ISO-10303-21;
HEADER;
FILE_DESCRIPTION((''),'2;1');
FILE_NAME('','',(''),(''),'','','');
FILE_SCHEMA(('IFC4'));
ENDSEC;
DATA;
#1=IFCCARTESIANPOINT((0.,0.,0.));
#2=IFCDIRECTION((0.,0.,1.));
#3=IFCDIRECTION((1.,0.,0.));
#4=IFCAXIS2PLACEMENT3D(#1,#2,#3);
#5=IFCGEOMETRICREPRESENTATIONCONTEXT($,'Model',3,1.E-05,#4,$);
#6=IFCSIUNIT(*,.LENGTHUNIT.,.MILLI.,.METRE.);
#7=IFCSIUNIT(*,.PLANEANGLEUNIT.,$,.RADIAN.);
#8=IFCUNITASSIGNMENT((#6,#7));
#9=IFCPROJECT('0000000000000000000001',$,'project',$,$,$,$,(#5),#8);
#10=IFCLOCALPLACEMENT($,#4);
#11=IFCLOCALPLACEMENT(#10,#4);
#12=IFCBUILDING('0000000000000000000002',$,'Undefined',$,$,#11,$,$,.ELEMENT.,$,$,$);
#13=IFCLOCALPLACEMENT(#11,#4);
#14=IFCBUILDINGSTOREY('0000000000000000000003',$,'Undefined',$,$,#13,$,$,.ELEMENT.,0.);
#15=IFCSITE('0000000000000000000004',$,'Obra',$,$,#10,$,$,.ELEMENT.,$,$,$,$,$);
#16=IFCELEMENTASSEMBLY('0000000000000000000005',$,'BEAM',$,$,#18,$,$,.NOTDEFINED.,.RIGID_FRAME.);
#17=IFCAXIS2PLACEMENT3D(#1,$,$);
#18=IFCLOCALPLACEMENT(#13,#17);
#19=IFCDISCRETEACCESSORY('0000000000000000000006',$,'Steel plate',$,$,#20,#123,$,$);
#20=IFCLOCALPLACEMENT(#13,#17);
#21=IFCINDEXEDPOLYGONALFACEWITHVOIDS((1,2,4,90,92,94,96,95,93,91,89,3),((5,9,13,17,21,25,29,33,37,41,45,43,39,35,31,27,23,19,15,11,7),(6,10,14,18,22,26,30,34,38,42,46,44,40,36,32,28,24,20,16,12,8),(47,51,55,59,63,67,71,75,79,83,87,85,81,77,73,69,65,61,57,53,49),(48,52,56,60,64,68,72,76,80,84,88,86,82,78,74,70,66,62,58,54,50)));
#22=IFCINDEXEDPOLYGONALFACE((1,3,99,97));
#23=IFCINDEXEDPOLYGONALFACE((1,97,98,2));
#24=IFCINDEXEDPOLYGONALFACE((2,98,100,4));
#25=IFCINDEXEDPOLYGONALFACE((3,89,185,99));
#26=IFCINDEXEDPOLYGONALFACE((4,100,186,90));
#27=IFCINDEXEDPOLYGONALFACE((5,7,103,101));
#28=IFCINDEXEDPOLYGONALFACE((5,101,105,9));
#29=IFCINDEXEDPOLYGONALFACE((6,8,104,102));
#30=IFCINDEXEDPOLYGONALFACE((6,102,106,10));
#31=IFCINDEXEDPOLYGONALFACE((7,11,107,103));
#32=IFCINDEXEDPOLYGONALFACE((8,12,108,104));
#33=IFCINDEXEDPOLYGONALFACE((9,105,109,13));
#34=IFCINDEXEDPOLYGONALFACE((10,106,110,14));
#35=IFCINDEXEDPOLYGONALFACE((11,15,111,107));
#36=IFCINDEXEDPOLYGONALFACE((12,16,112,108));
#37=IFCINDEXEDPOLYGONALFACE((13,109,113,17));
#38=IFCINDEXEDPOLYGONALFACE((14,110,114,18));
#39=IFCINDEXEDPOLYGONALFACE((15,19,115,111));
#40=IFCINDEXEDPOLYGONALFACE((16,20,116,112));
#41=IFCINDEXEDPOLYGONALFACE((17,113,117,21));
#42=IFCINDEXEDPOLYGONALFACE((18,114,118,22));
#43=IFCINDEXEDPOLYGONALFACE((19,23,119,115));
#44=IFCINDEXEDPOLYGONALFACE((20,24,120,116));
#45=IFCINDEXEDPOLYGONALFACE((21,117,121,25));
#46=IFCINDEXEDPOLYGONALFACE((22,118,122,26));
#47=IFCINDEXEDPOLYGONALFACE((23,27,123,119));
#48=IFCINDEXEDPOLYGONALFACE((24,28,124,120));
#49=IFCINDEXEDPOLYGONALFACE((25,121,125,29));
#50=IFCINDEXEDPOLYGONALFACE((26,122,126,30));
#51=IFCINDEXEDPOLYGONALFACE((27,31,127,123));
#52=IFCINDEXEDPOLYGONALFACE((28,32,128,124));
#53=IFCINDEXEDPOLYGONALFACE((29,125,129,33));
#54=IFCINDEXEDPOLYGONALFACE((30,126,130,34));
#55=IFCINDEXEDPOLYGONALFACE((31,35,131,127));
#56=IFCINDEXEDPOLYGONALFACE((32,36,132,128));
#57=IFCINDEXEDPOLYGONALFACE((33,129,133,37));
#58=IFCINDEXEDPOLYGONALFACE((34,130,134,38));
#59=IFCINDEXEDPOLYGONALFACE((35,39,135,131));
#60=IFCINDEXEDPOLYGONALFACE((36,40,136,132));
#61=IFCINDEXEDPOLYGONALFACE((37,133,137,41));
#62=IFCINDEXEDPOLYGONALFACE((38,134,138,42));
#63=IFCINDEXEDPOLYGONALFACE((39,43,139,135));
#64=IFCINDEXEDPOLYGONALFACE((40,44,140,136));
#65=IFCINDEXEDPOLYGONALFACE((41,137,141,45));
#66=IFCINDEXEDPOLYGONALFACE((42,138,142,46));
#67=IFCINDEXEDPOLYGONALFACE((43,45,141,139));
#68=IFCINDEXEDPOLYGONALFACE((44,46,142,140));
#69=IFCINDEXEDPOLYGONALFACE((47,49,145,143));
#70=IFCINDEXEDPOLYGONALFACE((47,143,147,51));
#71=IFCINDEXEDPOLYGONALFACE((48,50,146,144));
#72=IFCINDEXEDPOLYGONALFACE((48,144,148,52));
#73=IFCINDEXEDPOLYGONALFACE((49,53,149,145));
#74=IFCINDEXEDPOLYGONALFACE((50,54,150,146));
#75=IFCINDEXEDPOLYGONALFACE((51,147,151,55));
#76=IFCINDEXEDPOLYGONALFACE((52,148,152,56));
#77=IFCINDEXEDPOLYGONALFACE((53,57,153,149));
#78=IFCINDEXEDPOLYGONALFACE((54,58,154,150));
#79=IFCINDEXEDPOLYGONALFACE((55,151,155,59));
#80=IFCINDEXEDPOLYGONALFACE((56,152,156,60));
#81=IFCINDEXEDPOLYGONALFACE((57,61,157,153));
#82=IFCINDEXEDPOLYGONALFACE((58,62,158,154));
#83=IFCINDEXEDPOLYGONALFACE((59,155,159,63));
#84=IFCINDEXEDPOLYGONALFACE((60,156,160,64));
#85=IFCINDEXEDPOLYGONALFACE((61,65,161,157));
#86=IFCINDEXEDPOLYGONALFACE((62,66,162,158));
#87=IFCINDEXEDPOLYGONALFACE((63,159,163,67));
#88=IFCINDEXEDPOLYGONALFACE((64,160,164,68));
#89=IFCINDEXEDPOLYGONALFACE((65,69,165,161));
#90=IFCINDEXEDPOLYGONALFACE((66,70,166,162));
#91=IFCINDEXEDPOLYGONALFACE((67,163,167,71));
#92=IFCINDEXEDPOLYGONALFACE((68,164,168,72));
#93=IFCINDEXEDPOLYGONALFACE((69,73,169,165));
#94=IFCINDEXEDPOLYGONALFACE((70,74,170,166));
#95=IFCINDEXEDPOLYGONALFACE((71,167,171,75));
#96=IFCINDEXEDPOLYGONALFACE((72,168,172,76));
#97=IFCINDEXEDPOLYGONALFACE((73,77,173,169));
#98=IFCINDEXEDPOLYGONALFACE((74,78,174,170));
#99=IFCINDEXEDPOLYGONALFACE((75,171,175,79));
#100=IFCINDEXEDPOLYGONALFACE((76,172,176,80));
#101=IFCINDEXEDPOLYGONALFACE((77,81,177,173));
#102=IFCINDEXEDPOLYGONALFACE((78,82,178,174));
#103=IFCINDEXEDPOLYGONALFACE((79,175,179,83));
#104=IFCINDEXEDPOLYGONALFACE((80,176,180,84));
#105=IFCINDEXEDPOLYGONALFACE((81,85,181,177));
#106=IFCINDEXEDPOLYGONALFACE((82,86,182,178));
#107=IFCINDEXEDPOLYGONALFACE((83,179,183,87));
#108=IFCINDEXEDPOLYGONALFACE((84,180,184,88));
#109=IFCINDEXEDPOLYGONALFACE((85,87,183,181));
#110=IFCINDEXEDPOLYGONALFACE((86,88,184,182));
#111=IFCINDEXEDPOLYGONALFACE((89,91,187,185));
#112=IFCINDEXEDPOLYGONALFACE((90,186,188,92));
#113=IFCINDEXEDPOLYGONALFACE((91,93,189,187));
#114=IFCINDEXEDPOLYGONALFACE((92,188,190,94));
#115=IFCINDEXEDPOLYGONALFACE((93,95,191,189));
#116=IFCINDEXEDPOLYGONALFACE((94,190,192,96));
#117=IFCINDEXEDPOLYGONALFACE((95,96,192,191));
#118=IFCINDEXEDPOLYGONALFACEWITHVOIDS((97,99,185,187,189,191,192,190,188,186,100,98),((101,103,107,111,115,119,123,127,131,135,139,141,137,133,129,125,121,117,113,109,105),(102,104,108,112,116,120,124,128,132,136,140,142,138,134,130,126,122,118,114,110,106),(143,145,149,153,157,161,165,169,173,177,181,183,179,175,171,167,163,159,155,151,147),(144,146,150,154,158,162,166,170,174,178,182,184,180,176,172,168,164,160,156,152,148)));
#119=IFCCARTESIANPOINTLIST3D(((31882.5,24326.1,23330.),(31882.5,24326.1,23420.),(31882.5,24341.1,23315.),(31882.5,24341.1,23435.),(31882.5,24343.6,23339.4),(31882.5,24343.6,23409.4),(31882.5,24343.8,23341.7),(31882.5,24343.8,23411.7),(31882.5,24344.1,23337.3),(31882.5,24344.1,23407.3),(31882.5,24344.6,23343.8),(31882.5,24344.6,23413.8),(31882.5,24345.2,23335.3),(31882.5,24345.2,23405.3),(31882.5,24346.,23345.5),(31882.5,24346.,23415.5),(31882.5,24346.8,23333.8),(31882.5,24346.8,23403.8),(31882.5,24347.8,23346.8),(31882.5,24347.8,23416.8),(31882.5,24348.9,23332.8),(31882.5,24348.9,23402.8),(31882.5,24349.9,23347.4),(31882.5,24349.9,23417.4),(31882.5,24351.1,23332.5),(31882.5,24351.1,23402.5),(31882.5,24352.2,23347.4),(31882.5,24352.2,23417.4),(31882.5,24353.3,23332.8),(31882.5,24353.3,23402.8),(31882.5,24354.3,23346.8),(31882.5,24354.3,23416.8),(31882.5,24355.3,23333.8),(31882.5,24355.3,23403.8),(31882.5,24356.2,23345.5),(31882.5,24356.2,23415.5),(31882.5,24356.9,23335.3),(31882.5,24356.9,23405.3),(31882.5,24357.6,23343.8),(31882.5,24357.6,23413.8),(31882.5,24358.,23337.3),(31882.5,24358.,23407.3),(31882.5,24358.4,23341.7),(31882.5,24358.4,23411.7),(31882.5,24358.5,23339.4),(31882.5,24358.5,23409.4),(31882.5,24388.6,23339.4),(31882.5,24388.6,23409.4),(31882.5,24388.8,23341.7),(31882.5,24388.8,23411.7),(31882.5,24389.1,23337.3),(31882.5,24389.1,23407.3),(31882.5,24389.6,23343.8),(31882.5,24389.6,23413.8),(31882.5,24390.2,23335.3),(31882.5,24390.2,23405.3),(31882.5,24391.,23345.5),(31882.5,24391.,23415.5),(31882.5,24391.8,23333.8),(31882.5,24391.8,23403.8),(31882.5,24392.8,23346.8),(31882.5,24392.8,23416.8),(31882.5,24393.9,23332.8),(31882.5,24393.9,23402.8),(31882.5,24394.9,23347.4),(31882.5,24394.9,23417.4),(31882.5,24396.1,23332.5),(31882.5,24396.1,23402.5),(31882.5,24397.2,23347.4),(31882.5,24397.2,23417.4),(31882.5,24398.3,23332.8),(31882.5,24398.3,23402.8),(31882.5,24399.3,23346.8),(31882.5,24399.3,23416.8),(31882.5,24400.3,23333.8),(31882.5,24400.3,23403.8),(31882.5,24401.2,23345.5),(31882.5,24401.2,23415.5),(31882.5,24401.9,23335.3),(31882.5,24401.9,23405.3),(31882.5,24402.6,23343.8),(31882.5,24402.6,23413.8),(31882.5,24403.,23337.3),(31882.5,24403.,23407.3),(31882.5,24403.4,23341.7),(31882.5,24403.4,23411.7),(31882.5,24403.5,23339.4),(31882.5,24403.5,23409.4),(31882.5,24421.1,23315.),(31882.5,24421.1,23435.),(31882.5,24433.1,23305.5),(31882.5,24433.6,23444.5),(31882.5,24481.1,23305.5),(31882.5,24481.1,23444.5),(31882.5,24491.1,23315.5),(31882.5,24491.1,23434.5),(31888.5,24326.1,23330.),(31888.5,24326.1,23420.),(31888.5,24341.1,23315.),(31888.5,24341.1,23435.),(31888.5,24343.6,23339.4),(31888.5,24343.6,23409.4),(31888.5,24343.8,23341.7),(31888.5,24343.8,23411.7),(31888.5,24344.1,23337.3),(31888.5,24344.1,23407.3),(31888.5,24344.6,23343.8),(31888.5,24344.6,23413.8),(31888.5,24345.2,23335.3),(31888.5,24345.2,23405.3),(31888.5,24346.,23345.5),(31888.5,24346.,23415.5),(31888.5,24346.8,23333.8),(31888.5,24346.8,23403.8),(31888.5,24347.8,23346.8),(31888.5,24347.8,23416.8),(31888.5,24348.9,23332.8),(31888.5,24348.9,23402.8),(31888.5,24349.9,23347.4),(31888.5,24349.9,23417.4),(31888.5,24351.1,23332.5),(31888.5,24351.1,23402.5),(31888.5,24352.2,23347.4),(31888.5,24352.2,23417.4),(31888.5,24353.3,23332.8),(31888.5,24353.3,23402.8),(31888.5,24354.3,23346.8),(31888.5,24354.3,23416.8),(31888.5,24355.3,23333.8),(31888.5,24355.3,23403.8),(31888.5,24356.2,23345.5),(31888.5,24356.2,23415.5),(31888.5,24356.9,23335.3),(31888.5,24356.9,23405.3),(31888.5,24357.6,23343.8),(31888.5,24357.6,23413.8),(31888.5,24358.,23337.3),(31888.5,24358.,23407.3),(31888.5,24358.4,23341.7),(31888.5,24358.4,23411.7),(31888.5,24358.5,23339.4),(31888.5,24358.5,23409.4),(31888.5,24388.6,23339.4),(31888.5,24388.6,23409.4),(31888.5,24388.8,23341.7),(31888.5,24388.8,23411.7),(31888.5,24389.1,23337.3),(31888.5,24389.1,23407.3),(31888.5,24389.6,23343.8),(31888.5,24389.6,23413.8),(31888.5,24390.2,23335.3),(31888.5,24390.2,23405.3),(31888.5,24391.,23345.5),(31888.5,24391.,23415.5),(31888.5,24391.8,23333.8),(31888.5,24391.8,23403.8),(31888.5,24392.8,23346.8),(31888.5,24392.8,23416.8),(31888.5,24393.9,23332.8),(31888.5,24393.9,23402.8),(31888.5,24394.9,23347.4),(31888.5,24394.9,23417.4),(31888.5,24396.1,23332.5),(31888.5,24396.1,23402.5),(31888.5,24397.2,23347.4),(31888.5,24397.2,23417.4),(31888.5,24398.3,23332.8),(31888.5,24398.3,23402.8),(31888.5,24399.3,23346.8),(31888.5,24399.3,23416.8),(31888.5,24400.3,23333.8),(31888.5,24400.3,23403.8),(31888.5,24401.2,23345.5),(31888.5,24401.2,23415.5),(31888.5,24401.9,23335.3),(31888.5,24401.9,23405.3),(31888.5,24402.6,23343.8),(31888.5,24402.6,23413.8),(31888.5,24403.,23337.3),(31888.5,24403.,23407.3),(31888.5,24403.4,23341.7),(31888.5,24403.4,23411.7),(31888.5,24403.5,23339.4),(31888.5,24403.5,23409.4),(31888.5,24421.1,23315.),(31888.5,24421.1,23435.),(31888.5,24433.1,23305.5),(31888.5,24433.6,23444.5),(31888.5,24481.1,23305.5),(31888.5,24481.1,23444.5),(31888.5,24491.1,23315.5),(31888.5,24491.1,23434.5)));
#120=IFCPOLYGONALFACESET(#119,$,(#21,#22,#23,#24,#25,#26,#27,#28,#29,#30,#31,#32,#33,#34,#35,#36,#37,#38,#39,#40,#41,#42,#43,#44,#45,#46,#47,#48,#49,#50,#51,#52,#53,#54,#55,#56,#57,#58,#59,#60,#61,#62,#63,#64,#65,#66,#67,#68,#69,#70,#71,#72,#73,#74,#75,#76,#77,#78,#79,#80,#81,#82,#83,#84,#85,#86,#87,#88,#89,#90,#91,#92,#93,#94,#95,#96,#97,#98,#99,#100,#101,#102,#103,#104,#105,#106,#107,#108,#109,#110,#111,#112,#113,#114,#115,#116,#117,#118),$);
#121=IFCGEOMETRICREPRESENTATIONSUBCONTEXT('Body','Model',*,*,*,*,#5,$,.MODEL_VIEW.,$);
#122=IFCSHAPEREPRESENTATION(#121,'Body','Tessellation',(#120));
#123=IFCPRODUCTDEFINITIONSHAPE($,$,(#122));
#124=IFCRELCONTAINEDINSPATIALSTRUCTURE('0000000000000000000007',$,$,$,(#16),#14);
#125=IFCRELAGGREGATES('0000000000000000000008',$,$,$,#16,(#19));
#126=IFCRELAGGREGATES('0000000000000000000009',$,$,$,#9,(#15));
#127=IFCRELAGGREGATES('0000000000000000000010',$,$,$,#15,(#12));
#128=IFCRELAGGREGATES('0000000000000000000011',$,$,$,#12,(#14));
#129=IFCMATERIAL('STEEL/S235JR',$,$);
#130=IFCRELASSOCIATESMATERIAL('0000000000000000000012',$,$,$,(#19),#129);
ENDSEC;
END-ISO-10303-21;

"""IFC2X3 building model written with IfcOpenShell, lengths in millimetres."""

from ifc_helpers import new_model, si_unit, frame, origin_with_axes, origin_2d_with_axis, place, context, subcontext, project, spatial, polyline, circle, outline, extrude, source, transform, mapped, material, element, aggregate, save


model = new_model("IFC2X3")

# Units and contexts
model_context = context("Model", 3, precision=1e-05, world=origin_with_axes())
body_context = subcontext(model_context, "Body", "Model", "MODEL_VIEW")
ifc_project = project(units=[si_unit("LENGTHUNIT", "METRE", prefix="MILLI"), si_unit("PLANEANGLEUNIT", "RADIAN")], contexts=[model_context])

# Site, building, storey
site_placement = place(None, origin_with_axes())
site = spatial("IfcSite", under=ifc_project, at=site_placement, Name="Obra", CompositionType="ELEMENT")
building_placement = place(site_placement, origin_with_axes())
building = spatial("IfcBuilding", under=site, at=building_placement, Name="Undefined", CompositionType="ELEMENT")
storey_placement = place(building_placement, origin_with_axes())
storey = spatial("IfcBuildingStorey", under=building, at=storey_placement, Name="Undefined", CompositionType="ELEMENT", Elevation=0.0)

# Shared definitions
ifc_material_1 = material(Name="STEEL/S235JR")

# Element assembly
assembly_1_placement = place(storey_placement, origin_with_axes())
assembly_1 = element("IfcElementAssembly", 1, at=assembly_1_placement, inside=storey, Name="BEAM", AssemblyPlace="NOTDEFINED", PredefinedType="RIGID_FRAME")

# Discrete accessory, opening
shared_shape_1 = source(origin_with_axes(), body_context, "Body", "SweptSolid", [
    extrude(circle(Radius=7.5, at=origin_2d_with_axis()), frame((0.0, 2.4, 0.0), z_axis=(0.0, 1.0, 0.0), x_axis=(1.0, 0.0, 0.0)), (0.0, 0.0, 1.0), 6.2),
])
discrete_accessory_1_placement = place(assembly_1_placement, frame((31885.5, 24491.1, 23315.5), z_axis=(-1.0, 0.0, 0.0), x_axis=(0.000001, -0.707107, -0.707107)))
discrete_accessory_1 = element("IfcDiscreteAccessory", 2, at=discrete_accessory_1_placement, material=ifc_material_1, Name="Steel plate", context=body_context, shape_type="SweptSolid", body=[
    extrude(outline(polyline([(0.0, 0.0), (14.1, 0.0), (48.1, 33.9), (49.9, 49.1), (106.4, 105.7), (106.4, 126.9), (42.8, 190.6), (21.6, 190.6), (-35.0, 134.0), (-50.6, 131.9), (-84.1, 98.3), (-84.1, 84.1), (0.0, 0.0)])), frame((0.0, 0.0, -3.0), z_axis=(0.0, 0.0, 1.0), x_axis=(1.0, 0.0, 0.0)), (0.0, 0.0, 1.0), 6.0),
])
opening_1_placement = place(assembly_1_placement, frame((31880.0, 24373.6, 23410.0), z_axis=(0.0, -1.0, 0.0), x_axis=(0.0, 0.0, -1.0)))
element("IfcOpeningElement", 3, at=opening_1_placement, cuts=discrete_accessory_1, ObjectType="Opening", context=body_context, shape_type="MappedRepresentation", body=[
    mapped(shared_shape_1, transform((0.0, 0.0, -22.5))),
    mapped(shared_shape_1, transform((70.0, 0.0, -22.5))),
    mapped(shared_shape_1, transform((0.0, 0.0, 22.5))),
    mapped(shared_shape_1, transform((70.0, 0.0, 22.5))),
])

aggregate(assembly_1, [discrete_accessory_1])

save(model, "model.ifc")
